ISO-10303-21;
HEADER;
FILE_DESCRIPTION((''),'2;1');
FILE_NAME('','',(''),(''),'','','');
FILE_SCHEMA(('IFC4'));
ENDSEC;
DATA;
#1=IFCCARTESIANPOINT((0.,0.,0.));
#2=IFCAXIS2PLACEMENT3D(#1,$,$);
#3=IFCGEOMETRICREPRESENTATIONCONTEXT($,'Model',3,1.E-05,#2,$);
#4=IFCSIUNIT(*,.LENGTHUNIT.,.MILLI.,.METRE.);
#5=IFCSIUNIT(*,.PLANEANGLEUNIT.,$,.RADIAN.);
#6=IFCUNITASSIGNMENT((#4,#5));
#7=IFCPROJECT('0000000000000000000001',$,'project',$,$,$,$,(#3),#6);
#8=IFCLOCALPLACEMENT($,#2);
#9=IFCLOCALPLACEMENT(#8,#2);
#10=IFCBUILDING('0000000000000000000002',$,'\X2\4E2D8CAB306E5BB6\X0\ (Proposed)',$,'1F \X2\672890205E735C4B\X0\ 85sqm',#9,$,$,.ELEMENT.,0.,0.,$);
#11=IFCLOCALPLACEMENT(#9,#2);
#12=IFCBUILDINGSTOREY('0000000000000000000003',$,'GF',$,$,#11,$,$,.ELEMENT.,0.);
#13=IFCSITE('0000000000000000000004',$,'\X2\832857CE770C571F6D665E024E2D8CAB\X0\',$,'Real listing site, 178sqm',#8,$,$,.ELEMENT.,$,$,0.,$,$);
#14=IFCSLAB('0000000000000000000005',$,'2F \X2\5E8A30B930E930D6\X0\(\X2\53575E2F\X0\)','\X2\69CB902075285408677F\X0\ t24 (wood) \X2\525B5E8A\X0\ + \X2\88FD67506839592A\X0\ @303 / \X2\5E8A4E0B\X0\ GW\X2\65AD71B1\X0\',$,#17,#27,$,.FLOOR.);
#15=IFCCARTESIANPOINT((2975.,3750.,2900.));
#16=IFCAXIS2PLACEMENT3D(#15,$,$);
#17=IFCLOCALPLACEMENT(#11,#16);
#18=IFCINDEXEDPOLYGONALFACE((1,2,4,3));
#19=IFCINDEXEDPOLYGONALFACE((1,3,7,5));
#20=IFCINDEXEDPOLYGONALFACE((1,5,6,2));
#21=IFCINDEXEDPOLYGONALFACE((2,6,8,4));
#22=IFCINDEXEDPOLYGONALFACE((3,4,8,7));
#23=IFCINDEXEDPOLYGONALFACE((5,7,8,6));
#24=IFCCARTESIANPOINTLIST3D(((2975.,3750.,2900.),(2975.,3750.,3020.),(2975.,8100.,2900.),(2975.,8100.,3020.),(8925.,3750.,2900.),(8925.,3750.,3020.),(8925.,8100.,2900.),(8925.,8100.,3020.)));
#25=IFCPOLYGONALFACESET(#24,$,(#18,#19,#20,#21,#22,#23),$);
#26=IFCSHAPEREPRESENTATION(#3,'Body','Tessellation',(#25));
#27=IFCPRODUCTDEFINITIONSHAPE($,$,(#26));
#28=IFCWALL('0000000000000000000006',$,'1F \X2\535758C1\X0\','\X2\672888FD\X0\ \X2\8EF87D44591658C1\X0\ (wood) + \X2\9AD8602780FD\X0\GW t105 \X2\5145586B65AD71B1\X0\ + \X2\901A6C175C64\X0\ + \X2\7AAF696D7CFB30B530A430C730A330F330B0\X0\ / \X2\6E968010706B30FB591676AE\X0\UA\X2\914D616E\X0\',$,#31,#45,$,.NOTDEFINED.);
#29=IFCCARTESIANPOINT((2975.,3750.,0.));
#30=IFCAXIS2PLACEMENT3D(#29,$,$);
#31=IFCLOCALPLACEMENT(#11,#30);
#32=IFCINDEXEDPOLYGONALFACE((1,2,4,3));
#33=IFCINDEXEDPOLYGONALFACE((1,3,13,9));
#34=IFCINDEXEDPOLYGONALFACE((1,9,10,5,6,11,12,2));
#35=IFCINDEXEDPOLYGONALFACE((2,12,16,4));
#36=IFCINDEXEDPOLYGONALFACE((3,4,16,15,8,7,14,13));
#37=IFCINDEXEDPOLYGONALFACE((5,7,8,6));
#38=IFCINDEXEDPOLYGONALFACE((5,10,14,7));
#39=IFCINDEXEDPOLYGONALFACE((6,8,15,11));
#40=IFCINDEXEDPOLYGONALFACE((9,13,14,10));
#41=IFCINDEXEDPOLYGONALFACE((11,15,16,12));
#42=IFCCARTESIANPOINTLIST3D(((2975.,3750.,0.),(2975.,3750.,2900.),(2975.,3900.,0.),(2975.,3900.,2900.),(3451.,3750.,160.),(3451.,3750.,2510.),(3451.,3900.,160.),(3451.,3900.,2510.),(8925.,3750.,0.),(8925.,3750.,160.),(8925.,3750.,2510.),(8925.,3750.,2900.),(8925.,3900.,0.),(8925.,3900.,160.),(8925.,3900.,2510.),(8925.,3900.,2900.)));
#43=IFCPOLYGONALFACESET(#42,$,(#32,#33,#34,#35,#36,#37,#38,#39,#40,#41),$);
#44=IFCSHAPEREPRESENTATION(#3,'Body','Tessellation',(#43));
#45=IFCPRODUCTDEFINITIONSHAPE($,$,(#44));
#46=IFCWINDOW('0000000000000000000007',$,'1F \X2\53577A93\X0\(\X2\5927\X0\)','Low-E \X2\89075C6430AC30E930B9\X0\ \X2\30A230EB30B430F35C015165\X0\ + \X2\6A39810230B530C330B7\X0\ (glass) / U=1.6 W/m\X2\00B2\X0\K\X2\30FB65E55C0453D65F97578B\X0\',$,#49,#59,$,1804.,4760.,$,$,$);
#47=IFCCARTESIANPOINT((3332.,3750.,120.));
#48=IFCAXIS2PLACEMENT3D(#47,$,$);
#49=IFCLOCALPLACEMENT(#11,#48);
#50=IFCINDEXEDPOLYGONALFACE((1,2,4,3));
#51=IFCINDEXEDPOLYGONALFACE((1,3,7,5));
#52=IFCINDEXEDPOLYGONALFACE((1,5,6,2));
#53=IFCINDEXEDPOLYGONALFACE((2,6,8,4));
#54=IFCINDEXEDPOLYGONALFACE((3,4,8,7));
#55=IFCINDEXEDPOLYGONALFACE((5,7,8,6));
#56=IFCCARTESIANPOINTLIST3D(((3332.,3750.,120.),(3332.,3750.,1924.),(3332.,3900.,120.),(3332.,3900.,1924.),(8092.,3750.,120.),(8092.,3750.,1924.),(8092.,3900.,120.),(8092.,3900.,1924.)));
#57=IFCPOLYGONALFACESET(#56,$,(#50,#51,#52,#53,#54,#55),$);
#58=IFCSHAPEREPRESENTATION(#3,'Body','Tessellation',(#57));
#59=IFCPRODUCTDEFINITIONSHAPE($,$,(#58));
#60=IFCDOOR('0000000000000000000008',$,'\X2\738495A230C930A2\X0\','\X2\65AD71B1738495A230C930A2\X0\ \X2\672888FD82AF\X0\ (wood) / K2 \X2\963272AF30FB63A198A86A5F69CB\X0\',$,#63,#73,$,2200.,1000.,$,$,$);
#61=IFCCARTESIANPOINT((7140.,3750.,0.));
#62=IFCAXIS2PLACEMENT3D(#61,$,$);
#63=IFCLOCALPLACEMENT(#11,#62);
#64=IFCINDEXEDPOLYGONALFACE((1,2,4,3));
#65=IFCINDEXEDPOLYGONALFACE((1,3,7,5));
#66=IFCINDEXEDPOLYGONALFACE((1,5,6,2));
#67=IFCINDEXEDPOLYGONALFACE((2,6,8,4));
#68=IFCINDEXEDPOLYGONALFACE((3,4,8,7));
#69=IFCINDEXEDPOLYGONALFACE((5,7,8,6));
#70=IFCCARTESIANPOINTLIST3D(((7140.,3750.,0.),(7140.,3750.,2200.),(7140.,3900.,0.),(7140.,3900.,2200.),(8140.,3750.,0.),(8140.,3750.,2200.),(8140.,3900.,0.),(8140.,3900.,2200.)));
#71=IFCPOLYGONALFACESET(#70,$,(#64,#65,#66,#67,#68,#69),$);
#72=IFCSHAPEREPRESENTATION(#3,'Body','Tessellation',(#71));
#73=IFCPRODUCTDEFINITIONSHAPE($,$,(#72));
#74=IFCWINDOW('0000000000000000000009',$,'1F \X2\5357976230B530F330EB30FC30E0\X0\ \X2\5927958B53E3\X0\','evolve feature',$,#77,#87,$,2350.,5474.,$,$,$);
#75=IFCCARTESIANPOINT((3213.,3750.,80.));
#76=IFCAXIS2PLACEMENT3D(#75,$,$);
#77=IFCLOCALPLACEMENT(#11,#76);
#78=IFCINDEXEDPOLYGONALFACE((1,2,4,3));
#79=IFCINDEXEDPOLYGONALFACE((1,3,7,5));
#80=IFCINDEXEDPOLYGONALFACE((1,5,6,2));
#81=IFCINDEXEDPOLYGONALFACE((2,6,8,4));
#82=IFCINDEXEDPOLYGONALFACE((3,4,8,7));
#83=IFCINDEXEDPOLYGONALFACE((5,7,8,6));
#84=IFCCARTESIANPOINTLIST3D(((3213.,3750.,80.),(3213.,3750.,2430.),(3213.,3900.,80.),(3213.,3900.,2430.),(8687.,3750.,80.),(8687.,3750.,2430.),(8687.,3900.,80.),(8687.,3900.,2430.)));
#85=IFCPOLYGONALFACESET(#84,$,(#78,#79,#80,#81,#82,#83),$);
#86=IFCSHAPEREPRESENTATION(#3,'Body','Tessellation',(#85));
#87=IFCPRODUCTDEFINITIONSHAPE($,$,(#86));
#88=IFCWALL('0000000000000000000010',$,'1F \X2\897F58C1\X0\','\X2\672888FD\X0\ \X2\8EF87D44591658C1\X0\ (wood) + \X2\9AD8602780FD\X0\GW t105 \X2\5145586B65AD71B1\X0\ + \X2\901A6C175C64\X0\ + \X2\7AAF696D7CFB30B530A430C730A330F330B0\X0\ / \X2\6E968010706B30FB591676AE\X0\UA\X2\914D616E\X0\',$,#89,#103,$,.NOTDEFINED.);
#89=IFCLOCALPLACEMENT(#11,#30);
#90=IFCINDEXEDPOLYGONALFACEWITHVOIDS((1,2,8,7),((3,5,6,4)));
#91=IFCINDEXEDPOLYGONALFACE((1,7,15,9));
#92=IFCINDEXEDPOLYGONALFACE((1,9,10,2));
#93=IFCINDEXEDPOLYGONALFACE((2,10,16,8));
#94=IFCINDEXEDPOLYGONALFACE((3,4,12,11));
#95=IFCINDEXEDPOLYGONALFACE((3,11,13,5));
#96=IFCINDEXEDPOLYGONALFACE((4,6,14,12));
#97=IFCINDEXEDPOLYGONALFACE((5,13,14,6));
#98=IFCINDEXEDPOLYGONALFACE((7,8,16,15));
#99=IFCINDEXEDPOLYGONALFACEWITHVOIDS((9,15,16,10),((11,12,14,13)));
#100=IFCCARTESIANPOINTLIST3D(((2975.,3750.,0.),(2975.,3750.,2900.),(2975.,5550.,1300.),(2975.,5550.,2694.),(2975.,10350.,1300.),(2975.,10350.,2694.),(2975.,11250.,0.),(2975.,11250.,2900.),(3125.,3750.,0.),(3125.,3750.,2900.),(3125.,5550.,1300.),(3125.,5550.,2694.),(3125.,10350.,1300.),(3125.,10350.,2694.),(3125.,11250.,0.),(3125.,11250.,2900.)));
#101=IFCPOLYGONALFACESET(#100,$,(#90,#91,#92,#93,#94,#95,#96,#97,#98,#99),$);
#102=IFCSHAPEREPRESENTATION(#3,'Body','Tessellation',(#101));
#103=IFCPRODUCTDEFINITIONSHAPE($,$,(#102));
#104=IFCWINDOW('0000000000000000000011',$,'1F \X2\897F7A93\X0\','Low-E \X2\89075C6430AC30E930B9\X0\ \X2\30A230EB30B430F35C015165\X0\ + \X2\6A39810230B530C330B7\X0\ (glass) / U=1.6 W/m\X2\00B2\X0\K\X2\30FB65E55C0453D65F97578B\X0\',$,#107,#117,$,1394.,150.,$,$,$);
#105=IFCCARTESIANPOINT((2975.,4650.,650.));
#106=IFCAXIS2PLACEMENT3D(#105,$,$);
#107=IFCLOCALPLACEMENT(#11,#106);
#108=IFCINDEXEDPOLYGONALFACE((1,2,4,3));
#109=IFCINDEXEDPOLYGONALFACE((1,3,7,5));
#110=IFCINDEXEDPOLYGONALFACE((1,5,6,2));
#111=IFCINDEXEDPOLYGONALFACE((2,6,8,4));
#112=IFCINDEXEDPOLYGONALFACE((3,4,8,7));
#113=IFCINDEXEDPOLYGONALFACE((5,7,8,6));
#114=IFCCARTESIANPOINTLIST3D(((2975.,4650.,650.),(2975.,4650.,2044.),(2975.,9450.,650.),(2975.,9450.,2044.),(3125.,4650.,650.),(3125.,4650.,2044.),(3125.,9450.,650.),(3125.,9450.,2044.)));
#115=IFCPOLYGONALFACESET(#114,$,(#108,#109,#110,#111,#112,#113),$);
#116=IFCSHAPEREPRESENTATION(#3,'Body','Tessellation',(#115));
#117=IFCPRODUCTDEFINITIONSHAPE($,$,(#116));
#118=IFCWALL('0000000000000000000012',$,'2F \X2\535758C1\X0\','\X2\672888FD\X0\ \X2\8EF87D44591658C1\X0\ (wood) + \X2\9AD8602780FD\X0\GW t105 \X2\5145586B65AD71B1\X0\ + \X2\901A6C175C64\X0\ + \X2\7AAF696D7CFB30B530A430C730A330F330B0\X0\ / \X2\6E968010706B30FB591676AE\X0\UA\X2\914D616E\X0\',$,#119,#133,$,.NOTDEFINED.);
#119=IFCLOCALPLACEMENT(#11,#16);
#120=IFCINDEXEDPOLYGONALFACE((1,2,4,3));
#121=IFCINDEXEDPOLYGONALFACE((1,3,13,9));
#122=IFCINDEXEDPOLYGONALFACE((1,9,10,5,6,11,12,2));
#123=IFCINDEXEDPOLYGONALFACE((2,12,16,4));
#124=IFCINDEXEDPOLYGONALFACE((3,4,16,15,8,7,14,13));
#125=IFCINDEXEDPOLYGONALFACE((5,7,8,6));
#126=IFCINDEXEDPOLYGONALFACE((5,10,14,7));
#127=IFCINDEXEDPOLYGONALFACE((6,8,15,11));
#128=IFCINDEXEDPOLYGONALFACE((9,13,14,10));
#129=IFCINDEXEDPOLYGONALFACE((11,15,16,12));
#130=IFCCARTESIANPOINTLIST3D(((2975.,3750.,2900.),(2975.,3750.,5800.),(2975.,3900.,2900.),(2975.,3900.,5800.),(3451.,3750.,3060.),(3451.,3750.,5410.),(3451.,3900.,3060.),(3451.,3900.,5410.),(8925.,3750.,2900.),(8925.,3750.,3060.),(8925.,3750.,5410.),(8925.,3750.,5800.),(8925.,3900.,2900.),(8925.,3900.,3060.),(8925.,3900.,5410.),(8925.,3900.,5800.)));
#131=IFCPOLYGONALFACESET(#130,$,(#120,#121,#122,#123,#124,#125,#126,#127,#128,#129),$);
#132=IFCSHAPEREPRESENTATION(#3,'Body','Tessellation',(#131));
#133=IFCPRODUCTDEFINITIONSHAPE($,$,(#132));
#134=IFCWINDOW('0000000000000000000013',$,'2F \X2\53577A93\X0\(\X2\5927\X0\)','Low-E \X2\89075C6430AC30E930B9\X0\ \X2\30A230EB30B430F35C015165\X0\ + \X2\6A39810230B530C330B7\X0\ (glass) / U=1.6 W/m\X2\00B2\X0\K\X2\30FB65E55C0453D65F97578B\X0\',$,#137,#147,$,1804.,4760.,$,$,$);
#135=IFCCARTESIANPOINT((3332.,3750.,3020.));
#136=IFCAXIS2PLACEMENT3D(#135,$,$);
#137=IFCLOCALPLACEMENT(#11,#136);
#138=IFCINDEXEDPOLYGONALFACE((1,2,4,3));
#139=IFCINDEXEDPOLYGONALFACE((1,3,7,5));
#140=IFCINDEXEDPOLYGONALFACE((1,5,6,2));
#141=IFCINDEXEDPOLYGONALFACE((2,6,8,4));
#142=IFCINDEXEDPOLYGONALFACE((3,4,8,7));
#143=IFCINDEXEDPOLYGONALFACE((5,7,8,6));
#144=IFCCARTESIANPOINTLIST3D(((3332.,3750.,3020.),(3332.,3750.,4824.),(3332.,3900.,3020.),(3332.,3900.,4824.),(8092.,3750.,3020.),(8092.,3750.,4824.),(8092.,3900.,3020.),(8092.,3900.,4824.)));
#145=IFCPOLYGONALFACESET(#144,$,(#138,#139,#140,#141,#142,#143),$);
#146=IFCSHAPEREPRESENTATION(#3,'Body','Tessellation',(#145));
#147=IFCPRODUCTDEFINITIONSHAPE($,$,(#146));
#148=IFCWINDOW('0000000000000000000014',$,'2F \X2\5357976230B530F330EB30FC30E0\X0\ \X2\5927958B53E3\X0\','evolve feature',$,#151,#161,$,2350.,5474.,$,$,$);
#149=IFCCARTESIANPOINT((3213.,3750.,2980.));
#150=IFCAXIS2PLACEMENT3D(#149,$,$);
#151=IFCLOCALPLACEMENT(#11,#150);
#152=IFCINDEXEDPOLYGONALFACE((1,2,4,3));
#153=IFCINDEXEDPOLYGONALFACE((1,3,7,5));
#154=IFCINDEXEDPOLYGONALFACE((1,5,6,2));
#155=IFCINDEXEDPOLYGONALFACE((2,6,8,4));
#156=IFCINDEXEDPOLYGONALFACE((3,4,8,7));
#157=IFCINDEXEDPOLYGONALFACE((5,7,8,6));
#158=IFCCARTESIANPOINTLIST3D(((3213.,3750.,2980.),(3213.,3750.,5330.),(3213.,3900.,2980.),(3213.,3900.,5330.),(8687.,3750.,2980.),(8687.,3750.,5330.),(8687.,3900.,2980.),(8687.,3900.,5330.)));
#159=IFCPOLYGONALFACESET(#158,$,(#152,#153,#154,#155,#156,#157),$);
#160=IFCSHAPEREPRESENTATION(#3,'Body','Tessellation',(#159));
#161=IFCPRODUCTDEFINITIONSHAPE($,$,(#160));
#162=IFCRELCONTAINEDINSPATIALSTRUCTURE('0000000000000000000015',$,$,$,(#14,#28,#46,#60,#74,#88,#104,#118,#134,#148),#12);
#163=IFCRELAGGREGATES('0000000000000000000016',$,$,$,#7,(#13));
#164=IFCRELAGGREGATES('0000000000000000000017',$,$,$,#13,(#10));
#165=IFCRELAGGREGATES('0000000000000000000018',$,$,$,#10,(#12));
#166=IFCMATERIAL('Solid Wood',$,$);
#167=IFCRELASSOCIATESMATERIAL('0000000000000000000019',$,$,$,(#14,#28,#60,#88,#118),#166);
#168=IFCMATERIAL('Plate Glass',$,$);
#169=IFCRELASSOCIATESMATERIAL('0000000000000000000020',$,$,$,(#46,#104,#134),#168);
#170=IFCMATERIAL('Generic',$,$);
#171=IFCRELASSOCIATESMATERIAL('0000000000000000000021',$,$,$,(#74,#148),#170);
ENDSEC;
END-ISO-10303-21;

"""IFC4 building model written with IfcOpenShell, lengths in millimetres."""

from ifc_helpers import new_model, si_unit, frame, frame_2d, origin, place, context, project, spatial, rectangle, extrude, material, element, fill, save


model = new_model("IFC4")

# Units and contexts
model_context = context("Model", 3, precision=1e-05, world=origin())
ifc_project = project(units=[si_unit("LENGTHUNIT", "METRE", prefix="MILLI"), si_unit("PLANEANGLEUNIT", "RADIAN")], contexts=[model_context])

# Site, building, storey
site_placement = place(None, origin())
site = spatial("IfcSite", under=ifc_project, at=site_placement, Name="茨城県土浦市中貫", ObjectType="Real listing site, 178sqm", CompositionType="ELEMENT", RefElevation=0.0)
building_placement = place(site_placement, origin())
building = spatial("IfcBuilding", under=site, at=building_placement, Name="中貫の家 (Proposed)", ObjectType="1F 木造平屋 85sqm", CompositionType="ELEMENT", ElevationOfRefHeight=0.0, ElevationOfTerrain=0.0)
storey_placement = place(building_placement, origin())
storey = spatial("IfcBuildingStorey", under=building, at=storey_placement, Name="GF", CompositionType="ELEMENT", Elevation=0.0)

# Slab
ifc_material_1 = material(Name="Solid Wood")
slab_1_placement = place(storey_placement, frame((2975.0, 3750.0, 2900.0)))
element("IfcSlab", 1, at=slab_1_placement, inside=storey, material=ifc_material_1, Name="2F 床スラブ(南帯)", Description="構造用合板 t24 (wood) 剛床 + 製材根太 @303 / 床下 GW断熱", PredefinedType="FLOOR", context=model_context, shape_type="SweptSolid", body=[
    extrude(rectangle(XDim=5950.0, YDim=4350.0, at=frame_2d((2975.0, 2175.0))), frame((2975.0, 3750.0, 2900.0)), (0.0, 0.0, 1.0), 120.0),
])
ifc_material_2 = material(Name="Generic")

# Wall, openings, windows, door
wall_1_placement = place(storey_placement, frame((2975.0, 3750.0, 0.0)))
wall_1 = element("IfcWall", 2, at=wall_1_placement, inside=storey, material=ifc_material_1, Name="1F 南壁", Description="木製 軸組外壁 (wood) + 高性能GW t105 充填断熱 + 通気層 + 窯業系サイディング / 準耐火・外皮UA配慮", PredefinedType="NOTDEFINED", context=model_context, shape_type="SweptSolid", body=[
    extrude(rectangle(XDim=5950.0, YDim=150.0, at=frame_2d((2975.0, 75.0))), frame((2975.0, 3750.0, 0.0)), (0.0, 0.0, 1.0), 2900.0),
])
opening_1_placement = place(storey_placement, frame((3332.0, 3750.0, 120.0)))
opening_1 = element("IfcOpeningElement", 3, at=opening_1_placement, cuts=wall_1, PredefinedType="NOTDEFINED", context=model_context, shape_type="SweptSolid", body=[
    extrude(rectangle(XDim=4760.0, YDim=150.0, at=frame_2d((2380.0, 75.0))), frame((3332.0, 3750.0, 120.0)), (0.0, 0.0, 1.0), 1804.0),
])
opening_2_placement = place(storey_placement, frame((7140.0, 3750.0, 0.0)))
opening_2 = element("IfcOpeningElement", 4, at=opening_2_placement, cuts=wall_1, PredefinedType="NOTDEFINED", context=model_context, shape_type="SweptSolid", body=[
    extrude(rectangle(XDim=1000.0, YDim=150.0, at=frame_2d((500.0, 75.0))), frame((7140.0, 3750.0, 0.0)), (0.0, 0.0, 1.0), 2200.0),
])
opening_3_placement = place(storey_placement, frame((3213.0, 3750.0, 80.0)))
opening_3 = element("IfcOpeningElement", 5, at=opening_3_placement, cuts=wall_1, PredefinedType="NOTDEFINED", context=model_context, shape_type="SweptSolid", body=[
    extrude(rectangle(XDim=5474.0, YDim=150.0, at=frame_2d((2737.0, 75.0))), frame((3213.0, 3750.0, 80.0)), (0.0, 0.0, 1.0), 2350.0),
])
ifc_material_3 = material(Name="Plate Glass")
window_1_placement = place(storey_placement, frame((3332.0, 3750.0, 120.0)))
window_1 = element("IfcWindow", 6, at=window_1_placement, inside=storey, material=ifc_material_3, Name="1F 南窓(大)", Description="Low-E 複層ガラス アルゴン封入 + 樹脂サッシ (glass) / U=1.6 W/m²K・日射取得型", OverallHeight=1804.0, OverallWidth=4760.0, context=model_context, shape_type="SweptSolid", body=[
    extrude(rectangle(XDim=4760.0, YDim=150.0, at=frame_2d((2380.0, 75.0))), frame((3332.0, 3750.0, 120.0)), (0.0, 0.0, 1.0), 1804.0),
])
fill(opening_1, window_1)
door_placement = place(storey_placement, frame((7140.0, 3750.0, 0.0)))
door = element("IfcDoor", 7, at=door_placement, inside=storey, material=ifc_material_1, Name="玄関ドア", Description="断熱玄関ドア 木製芯 (wood) / K2 防犯・採風機構", OverallHeight=2200.0, OverallWidth=1000.0, context=model_context, shape_type="SweptSolid", body=[
    extrude(rectangle(XDim=1000.0, YDim=150.0, at=frame_2d((500.0, 75.0))), frame((7140.0, 3750.0, 0.0)), (0.0, 0.0, 1.0), 2200.0),
])
fill(opening_2, door)
window_2_placement = place(storey_placement, frame((3213.0, 3750.0, 80.0)))
window_2 = element("IfcWindow", 8, at=window_2_placement, inside=storey, material=ifc_material_2, Name="1F 南面サンルーム 大開口", Description="evolve feature", OverallHeight=2350.0, OverallWidth=5474.0, context=model_context, shape_type="SweptSolid", body=[
    extrude(rectangle(XDim=5474.0, YDim=150.0, at=frame_2d((2737.0, 75.0))), frame((3213.0, 3750.0, 80.0)), (0.0, 0.0, 1.0), 2350.0),
])
fill(opening_3, window_2)

# Wall, opening, window
wall_2_placement = place(storey_placement, frame((2975.0, 3750.0, 0.0)))
wall_2 = element("IfcWall", 9, at=wall_2_placement, inside=storey, material=ifc_material_1, Name="1F 西壁", Description="木製 軸組外壁 (wood) + 高性能GW t105 充填断熱 + 通気層 + 窯業系サイディング / 準耐火・外皮UA配慮", PredefinedType="NOTDEFINED", context=model_context, shape_type="SweptSolid", body=[
    extrude(rectangle(XDim=150.0, YDim=7500.0, at=frame_2d((75.0, 3750.0))), frame((2975.0, 3750.0, 0.0)), (0.0, 0.0, 1.0), 2900.0),
])
opening_4_placement = place(storey_placement, frame((2975.0, 4650.0, 650.0)))
opening_4 = element("IfcOpeningElement", 10, at=opening_4_placement, cuts=wall_2, PredefinedType="NOTDEFINED", context=model_context, shape_type="SweptSolid", body=[
    extrude(rectangle(XDim=150.0, YDim=4800.0, at=frame_2d((75.0, 2400.0))), frame((2975.0, 4650.0, 650.0)), (0.0, 0.0, 1.0), 1394.0),
])
window_3_placement = place(storey_placement, frame((2975.0, 4650.0, 650.0)))
window_3 = element("IfcWindow", 11, at=window_3_placement, inside=storey, material=ifc_material_3, Name="1F 西窓", Description="Low-E 複層ガラス アルゴン封入 + 樹脂サッシ (glass) / U=1.6 W/m²K・日射取得型", OverallHeight=1394.0, OverallWidth=150.0, context=model_context, shape_type="SweptSolid", body=[
    extrude(rectangle(XDim=150.0, YDim=4800.0, at=frame_2d((75.0, 2400.0))), frame((2975.0, 4650.0, 650.0)), (0.0, 0.0, 1.0), 1394.0),
])
fill(opening_4, window_3)

# Wall, openings, windows
wall_3_placement = place(storey_placement, frame((2975.0, 3750.0, 2900.0)))
wall_3 = element("IfcWall", 12, at=wall_3_placement, inside=storey, material=ifc_material_1, Name="2F 南壁", Description="木製 軸組外壁 (wood) + 高性能GW t105 充填断熱 + 通気層 + 窯業系サイディング / 準耐火・外皮UA配慮", PredefinedType="NOTDEFINED", context=model_context, shape_type="SweptSolid", body=[
    extrude(rectangle(XDim=5950.0, YDim=150.0, at=frame_2d((2975.0, 75.0))), frame((2975.0, 3750.0, 2900.0)), (0.0, 0.0, 1.0), 2900.0),
])
opening_5_placement = place(storey_placement, frame((3332.0, 3750.0, 3020.0)))
opening_5 = element("IfcOpeningElement", 13, at=opening_5_placement, cuts=wall_3, PredefinedType="NOTDEFINED", context=model_context, shape_type="SweptSolid", body=[
    extrude(rectangle(XDim=4760.0, YDim=150.0, at=frame_2d((2380.0, 75.0))), frame((3332.0, 3750.0, 3020.0)), (0.0, 0.0, 1.0), 1804.0),
])
opening_6_placement = place(storey_placement, frame((3213.0, 3750.0, 2980.0)))
opening_6 = element("IfcOpeningElement", 14, at=opening_6_placement, cuts=wall_3, PredefinedType="NOTDEFINED", context=model_context, shape_type="SweptSolid", body=[
    extrude(rectangle(XDim=5474.0, YDim=150.0, at=frame_2d((2737.0, 75.0))), frame((3213.0, 3750.0, 2980.0)), (0.0, 0.0, 1.0), 2350.0),
])
window_4_placement = place(storey_placement, frame((3332.0, 3750.0, 3020.0)))
window_4 = element("IfcWindow", 15, at=window_4_placement, inside=storey, material=ifc_material_3, Name="2F 南窓(大)", Description="Low-E 複層ガラス アルゴン封入 + 樹脂サッシ (glass) / U=1.6 W/m²K・日射取得型", OverallHeight=1804.0, OverallWidth=4760.0, context=model_context, shape_type="SweptSolid", body=[
    extrude(rectangle(XDim=4760.0, YDim=150.0, at=frame_2d((2380.0, 75.0))), frame((3332.0, 3750.0, 3020.0)), (0.0, 0.0, 1.0), 1804.0),
])
fill(opening_5, window_4)
window_5_placement = place(storey_placement, frame((3213.0, 3750.0, 2980.0)))
window_5 = element("IfcWindow", 16, at=window_5_placement, inside=storey, material=ifc_material_2, Name="2F 南面サンルーム 大開口", Description="evolve feature", OverallHeight=2350.0, OverallWidth=5474.0, context=model_context, shape_type="SweptSolid", body=[
    extrude(rectangle(XDim=5474.0, YDim=150.0, at=frame_2d((2737.0, 75.0))), frame((3213.0, 3750.0, 2980.0)), (0.0, 0.0, 1.0), 2350.0),
])
fill(opening_6, window_5)

save(model, "model.ifc")
